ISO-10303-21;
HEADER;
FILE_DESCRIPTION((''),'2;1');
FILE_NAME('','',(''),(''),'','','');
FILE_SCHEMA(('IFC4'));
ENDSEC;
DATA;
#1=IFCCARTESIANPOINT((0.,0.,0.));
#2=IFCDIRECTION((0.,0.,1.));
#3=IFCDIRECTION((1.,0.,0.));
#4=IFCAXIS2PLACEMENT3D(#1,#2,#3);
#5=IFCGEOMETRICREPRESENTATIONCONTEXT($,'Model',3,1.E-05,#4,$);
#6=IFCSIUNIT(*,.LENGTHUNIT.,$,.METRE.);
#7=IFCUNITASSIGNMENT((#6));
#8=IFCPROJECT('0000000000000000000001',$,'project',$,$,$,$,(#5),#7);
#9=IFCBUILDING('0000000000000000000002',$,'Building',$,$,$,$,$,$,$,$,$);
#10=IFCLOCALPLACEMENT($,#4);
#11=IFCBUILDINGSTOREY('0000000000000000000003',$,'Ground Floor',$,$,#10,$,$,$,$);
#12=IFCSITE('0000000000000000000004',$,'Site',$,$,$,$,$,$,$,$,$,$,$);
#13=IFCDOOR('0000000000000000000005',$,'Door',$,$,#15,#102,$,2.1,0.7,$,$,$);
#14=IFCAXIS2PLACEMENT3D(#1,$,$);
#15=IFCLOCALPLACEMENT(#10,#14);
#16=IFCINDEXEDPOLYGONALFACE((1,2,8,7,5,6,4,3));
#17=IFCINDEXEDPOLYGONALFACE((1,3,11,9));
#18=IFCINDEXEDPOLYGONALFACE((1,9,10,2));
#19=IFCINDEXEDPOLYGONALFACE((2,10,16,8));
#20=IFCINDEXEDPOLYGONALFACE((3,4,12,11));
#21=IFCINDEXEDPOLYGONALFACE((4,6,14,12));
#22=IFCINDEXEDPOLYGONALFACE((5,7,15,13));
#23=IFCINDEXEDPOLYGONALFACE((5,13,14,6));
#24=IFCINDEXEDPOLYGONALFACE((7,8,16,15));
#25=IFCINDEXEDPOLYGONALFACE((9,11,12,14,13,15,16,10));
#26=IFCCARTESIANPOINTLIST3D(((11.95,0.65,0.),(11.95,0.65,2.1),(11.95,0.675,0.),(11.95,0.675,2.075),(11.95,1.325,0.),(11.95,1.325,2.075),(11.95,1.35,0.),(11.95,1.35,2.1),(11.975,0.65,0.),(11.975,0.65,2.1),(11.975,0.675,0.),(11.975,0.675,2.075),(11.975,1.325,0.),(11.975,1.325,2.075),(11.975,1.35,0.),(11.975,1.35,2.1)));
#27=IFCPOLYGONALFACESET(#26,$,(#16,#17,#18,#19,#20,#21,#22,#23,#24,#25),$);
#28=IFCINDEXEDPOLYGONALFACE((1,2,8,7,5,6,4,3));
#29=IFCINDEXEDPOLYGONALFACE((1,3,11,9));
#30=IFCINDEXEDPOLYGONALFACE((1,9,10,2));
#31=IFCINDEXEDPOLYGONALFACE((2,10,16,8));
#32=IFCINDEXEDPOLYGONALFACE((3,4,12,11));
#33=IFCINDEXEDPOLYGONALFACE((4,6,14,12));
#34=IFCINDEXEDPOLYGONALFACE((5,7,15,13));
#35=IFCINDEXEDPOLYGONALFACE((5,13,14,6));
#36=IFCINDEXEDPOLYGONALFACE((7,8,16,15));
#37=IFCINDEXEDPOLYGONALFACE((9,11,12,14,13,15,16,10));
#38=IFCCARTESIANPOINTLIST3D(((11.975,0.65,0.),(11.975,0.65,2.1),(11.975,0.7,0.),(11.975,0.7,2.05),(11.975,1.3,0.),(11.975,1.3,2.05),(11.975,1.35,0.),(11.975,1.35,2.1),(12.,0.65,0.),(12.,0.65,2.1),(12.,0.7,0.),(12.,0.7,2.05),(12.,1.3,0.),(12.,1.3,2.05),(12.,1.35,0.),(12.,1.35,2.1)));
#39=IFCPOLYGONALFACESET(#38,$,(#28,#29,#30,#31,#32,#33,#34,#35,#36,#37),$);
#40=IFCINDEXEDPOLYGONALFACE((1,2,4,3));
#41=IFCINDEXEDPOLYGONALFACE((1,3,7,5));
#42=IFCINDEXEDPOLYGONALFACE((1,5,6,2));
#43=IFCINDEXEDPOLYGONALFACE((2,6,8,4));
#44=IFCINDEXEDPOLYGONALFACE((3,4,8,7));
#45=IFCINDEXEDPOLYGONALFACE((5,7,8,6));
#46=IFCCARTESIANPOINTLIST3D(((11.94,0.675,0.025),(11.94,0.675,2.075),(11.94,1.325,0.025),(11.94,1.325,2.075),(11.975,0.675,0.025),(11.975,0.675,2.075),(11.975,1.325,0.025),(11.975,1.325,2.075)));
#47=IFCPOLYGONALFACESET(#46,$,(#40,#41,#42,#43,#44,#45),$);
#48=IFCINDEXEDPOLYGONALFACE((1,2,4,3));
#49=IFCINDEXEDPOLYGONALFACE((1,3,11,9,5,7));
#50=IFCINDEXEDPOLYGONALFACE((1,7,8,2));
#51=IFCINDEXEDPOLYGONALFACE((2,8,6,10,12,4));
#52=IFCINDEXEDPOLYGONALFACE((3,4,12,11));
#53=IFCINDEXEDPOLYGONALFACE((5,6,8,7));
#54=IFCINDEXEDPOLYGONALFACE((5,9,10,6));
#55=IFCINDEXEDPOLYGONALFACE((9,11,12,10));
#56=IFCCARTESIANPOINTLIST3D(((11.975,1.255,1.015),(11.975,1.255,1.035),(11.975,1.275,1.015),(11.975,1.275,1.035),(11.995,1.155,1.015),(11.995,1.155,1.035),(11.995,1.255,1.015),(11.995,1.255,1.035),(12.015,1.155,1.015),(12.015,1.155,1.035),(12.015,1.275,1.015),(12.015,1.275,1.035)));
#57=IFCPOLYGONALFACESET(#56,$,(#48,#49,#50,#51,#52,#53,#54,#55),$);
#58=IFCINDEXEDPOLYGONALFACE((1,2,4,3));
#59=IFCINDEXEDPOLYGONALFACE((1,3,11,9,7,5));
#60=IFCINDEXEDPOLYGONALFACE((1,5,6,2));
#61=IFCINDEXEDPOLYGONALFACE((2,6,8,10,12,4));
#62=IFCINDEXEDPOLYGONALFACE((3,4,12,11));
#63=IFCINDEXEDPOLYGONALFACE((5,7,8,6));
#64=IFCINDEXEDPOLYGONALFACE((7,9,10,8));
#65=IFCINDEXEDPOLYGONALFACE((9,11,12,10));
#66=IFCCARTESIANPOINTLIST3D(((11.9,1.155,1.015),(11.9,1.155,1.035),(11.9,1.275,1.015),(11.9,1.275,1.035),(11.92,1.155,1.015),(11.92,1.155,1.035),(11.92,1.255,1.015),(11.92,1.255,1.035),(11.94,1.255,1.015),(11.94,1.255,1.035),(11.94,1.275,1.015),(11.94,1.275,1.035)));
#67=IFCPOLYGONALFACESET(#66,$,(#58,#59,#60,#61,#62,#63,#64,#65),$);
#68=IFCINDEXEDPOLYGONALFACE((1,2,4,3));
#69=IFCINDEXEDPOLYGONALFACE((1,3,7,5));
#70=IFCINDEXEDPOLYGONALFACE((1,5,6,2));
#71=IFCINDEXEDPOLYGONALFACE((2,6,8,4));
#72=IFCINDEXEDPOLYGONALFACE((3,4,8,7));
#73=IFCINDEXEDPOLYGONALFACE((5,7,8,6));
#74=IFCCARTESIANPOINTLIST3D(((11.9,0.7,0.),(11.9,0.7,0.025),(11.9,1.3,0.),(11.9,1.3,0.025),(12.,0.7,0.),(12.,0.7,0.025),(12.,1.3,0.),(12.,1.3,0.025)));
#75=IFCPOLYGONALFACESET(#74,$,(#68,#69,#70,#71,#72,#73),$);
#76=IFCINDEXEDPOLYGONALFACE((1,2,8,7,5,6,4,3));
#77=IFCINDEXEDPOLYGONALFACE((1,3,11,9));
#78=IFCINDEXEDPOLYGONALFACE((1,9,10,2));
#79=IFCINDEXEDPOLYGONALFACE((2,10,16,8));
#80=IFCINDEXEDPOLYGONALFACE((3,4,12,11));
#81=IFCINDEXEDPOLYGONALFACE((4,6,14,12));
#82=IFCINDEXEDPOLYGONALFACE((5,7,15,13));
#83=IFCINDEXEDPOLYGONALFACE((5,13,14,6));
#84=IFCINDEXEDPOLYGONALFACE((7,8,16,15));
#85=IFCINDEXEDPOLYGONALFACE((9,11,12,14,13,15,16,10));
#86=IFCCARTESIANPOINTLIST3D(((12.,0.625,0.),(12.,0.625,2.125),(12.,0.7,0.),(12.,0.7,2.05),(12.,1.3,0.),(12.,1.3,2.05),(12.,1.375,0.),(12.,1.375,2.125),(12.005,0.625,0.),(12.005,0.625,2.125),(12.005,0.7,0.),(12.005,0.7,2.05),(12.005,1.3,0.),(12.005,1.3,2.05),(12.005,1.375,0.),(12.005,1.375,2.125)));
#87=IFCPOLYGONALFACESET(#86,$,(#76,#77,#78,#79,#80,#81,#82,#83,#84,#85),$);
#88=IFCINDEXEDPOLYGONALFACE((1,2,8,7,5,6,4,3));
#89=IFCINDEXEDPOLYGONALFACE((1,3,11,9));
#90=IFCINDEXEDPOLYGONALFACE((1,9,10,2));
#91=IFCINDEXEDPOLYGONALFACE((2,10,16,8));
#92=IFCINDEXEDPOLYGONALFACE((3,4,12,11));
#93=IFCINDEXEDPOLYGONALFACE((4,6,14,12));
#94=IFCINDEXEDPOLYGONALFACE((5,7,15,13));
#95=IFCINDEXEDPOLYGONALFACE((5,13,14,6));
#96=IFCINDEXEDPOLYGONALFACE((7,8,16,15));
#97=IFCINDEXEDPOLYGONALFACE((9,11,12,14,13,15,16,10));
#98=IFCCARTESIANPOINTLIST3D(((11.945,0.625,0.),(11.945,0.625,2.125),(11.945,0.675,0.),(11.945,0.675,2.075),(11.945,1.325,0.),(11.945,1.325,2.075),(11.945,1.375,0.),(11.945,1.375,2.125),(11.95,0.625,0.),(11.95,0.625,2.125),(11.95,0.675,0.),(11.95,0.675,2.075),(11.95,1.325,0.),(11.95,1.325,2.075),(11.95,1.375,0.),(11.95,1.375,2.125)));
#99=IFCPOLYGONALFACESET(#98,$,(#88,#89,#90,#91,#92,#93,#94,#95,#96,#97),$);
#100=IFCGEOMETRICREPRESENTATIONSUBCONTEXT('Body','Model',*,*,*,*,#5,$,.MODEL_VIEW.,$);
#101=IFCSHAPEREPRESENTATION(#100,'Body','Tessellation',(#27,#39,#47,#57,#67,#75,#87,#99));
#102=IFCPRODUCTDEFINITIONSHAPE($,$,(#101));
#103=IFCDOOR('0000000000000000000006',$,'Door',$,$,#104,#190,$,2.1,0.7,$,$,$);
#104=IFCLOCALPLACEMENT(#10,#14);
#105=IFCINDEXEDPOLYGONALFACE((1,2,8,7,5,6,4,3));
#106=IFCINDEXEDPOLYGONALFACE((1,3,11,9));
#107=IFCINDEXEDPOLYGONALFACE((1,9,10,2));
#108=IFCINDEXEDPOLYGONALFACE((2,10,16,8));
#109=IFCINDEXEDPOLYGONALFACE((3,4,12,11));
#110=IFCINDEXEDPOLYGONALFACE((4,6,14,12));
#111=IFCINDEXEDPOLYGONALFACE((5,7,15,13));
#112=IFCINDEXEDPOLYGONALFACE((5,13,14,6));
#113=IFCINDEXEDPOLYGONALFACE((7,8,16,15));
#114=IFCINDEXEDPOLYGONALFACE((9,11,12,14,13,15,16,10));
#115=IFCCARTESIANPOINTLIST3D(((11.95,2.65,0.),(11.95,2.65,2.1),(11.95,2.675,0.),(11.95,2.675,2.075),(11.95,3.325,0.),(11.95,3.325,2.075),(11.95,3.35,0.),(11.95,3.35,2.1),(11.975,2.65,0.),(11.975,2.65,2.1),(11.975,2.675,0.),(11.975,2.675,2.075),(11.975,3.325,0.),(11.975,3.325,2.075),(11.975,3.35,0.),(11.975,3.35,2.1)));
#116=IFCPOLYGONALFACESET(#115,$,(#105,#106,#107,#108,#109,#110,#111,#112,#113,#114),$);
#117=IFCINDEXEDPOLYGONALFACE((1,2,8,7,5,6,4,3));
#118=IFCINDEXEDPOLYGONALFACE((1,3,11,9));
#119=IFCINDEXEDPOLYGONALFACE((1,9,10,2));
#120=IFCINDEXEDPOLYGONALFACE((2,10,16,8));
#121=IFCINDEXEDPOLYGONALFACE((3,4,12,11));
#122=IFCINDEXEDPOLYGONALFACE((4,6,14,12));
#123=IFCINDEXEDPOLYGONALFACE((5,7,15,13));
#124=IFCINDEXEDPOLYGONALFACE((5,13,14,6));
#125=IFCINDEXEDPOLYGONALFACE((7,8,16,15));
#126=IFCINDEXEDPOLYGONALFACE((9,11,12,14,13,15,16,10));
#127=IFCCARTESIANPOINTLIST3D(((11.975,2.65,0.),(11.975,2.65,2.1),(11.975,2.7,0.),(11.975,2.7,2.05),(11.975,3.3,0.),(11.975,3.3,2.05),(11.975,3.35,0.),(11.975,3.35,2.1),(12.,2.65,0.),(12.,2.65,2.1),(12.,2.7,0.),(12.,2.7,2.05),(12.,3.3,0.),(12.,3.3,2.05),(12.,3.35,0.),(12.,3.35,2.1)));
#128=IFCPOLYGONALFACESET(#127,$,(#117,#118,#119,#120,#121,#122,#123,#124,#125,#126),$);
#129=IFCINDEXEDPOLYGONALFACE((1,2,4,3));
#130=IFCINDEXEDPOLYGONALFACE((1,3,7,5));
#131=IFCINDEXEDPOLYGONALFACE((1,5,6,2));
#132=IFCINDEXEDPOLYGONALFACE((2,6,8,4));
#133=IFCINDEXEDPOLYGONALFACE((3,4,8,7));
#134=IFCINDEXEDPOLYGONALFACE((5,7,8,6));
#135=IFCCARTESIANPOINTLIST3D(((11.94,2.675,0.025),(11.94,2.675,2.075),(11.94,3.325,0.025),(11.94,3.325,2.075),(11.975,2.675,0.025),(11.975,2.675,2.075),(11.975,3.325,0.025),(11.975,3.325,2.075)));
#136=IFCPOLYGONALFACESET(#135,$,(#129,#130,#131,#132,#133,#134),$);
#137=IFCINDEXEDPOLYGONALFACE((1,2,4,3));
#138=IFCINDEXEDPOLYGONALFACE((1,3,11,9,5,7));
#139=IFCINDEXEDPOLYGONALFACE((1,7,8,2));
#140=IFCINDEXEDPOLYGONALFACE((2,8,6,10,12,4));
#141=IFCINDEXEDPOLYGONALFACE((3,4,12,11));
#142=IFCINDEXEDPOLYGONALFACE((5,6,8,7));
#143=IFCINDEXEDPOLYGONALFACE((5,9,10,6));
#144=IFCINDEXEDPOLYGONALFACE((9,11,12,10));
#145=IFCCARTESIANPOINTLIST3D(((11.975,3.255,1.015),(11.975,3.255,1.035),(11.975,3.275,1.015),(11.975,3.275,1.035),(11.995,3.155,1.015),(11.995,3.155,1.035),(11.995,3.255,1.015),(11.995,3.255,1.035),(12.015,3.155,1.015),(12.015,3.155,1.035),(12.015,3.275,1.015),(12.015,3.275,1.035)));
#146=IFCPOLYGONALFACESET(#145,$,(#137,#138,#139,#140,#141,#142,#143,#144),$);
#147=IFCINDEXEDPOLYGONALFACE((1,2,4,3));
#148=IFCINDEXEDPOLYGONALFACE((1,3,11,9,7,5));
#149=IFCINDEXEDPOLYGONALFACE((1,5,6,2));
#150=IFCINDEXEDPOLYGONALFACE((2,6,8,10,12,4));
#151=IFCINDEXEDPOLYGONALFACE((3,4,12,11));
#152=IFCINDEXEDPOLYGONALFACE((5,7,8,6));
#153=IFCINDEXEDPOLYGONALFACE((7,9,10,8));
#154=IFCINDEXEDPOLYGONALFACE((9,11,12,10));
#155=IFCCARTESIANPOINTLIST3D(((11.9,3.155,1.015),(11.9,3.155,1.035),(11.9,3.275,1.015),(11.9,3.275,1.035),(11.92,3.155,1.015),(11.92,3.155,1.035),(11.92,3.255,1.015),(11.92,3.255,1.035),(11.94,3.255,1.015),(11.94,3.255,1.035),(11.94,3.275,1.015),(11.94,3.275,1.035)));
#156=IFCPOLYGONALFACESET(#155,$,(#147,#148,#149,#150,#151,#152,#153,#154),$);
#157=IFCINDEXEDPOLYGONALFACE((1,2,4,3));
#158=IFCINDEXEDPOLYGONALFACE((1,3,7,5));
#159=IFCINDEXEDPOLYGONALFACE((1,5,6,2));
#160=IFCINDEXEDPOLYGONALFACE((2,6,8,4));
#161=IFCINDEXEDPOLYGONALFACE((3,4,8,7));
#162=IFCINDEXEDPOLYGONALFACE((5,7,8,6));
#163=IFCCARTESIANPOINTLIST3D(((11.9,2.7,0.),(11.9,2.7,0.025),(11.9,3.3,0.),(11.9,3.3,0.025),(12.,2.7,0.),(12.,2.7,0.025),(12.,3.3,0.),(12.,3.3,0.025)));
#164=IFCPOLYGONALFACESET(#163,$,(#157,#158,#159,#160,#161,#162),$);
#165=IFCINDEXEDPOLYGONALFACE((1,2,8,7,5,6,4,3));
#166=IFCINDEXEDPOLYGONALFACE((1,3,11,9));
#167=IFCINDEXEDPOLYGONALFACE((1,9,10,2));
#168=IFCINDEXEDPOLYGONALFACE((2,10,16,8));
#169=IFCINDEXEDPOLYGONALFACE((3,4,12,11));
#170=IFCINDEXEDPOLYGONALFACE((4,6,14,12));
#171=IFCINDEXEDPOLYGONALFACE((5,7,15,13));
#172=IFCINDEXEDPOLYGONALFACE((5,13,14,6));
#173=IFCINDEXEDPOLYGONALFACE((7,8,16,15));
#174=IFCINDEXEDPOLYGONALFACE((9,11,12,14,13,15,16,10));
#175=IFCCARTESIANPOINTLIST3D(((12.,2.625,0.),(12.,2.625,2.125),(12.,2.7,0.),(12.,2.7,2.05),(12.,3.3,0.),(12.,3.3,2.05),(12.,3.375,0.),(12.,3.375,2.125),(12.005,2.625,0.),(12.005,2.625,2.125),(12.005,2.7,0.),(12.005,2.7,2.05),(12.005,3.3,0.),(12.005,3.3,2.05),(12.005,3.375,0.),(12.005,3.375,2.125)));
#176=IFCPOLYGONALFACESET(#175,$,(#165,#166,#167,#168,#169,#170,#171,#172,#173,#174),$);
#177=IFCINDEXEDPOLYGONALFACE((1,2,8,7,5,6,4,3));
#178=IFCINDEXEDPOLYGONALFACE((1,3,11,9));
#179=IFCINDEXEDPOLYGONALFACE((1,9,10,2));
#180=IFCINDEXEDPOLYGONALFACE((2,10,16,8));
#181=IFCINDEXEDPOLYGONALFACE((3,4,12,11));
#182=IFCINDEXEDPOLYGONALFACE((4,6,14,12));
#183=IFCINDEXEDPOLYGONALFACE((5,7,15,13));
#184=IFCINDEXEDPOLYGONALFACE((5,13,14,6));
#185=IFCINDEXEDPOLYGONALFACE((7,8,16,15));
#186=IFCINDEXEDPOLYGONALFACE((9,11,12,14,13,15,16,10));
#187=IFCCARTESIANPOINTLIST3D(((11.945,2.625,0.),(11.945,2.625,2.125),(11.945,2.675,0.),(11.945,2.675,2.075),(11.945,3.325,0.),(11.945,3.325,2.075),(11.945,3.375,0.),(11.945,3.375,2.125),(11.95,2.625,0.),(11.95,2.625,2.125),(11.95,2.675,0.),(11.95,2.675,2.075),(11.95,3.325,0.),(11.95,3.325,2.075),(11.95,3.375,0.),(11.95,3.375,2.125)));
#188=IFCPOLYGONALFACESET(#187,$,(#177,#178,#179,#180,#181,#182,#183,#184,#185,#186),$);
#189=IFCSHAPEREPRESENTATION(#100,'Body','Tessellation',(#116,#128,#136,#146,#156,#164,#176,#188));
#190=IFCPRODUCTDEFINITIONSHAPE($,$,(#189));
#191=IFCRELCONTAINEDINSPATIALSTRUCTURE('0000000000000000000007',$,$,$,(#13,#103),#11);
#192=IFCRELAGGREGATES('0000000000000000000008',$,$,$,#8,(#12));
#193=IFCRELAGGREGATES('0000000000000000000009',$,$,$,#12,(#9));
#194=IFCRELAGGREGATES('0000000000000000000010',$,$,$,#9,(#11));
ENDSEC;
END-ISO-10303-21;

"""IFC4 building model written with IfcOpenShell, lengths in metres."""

from ifc_helpers import new_model, si_unit, frame, origin_with_axes, place, context, subcontext, project, spatial, line, indexed_curve, outline, extrude, element, save


model = new_model("IFC4")

# Units and contexts
model_context = context("Model", 3, precision=1e-05, world=origin_with_axes())
body_context = subcontext(model_context, "Body", "Model", "MODEL_VIEW")
ifc_project = project(units=[si_unit("LENGTHUNIT", "METRE")], contexts=[model_context])

# Site, building, storey
site = spatial("IfcSite", under=ifc_project, Name="Site")
building = spatial("IfcBuilding", under=site, Name="Building")
storey_placement = place(None, origin_with_axes())
storey = spatial("IfcBuildingStorey", under=building, at=storey_placement, Name="Ground Floor")

# Doors
door_1_placement = place(storey_placement, frame((12.0, 0.65, 0.0), z_axis=(0.0, 0.0, 1.0), x_axis=(0.0, 1.0, 0.0)))
element("IfcDoor", 1, at=door_1_placement, inside=storey, Name="Door", OverallHeight=2.1, OverallWidth=0.7, context=body_context, shape_type="SweptSolid", body=[
    extrude(outline(indexed_curve([(0.0, 0.0), (0.0, 2.1), (0.7, 2.1), (0.7, 0.0), (0.675, 0.0), (0.675, 2.075), (0.025, 2.075), (0.025, 0.0)], segments=[line(1, 2, 3, 4, 5, 6, 7, 8, 1)])), frame((0.0, 0.025, 0.0), z_axis=(0.0, -1.0, 0.0), x_axis=(1.0, 0.0, 0.0)), (0.0, 0.0, -1.0), 0.025),
    extrude(outline(indexed_curve([(0.0, 0.0), (0.0, 2.1), (0.7, 2.1), (0.7, 0.0), (0.65, 0.0), (0.65, 2.05), (0.05, 2.05), (0.05, 0.0)], segments=[line(1, 2, 3, 4, 5, 6, 7, 8, 1)])), frame((0.0, 0.0, 0.0), z_axis=(0.0, -1.0, 0.0), x_axis=(1.0, 0.0, 0.0)), (0.0, 0.0, -1.0), 0.025),
    extrude(outline(indexed_curve([(0.0, 0.0), (0.65, 0.0), (0.65, 0.035), (0.0, 0.035)], segments=[line(1, 2, 3, 4, 1)])), frame((0.025, 0.025, 0.025), z_axis=(0.0, 0.0, 1.0), x_axis=(1.0, 0.0, 0.0)), (0.0, 0.0, 1.0), 2.05),
    extrude(outline(indexed_curve([(0.0, 0.0), (0.0, -0.04), (-0.12, -0.04), (-0.12, -0.02), (-0.02, -0.02), (-0.02, 0.0)], segments=[line(1, 2, 3, 4, 5, 6, 1)])), frame((0.625, 0.025, 1.015), z_axis=(0.0, 0.0, 1.0), x_axis=(1.0, 0.0, 0.0)), (0.0, 0.0, 1.0), 0.02),
    extrude(outline(indexed_curve([(0.0, 0.0), (0.0, 0.04), (-0.12, 0.04), (-0.12, 0.02), (-0.02, 0.02), (-0.02, 0.0)], segments=[line(1, 2, 3, 4, 5, 6, 1)])), frame((0.625, 0.06, 1.015), z_axis=(0.0, 0.0, 1.0), x_axis=(1.0, 0.0, 0.0)), (0.0, 0.0, 1.0), 0.02),
    extrude(outline(indexed_curve([(0.0, 0.0), (0.6, 0.0), (0.6, 0.1), (0.0, 0.1)], segments=[line(1, 2, 3, 4, 1)])), frame((0.05, 0.0, 0.0), z_axis=(0.0, 0.0, 1.0), x_axis=(1.0, 0.0, 0.0)), (0.0, 0.0, 1.0), 0.025),
    extrude(outline(indexed_curve([(0.0, 0.0), (0.0, 2.125), (0.75, 2.125), (0.75, 0.0), (0.675, 0.0), (0.675, 2.05), (0.075, 2.05), (0.075, 0.0)], segments=[line(1, 2, 3, 4, 5, 6, 7, 8, 1)])), frame((-0.025, -0.005, 0.0), z_axis=(0.0, -1.0, 0.0), x_axis=(1.0, 0.0, 0.0)), (0.0, 0.0, -1.0), 0.005),
    extrude(outline(indexed_curve([(0.0, 0.0), (0.0, 2.125), (0.75, 2.125), (0.75, 0.0), (0.7, 0.0), (0.7, 2.075), (0.05, 2.075), (0.05, 0.0)], segments=[line(1, 2, 3, 4, 5, 6, 7, 8, 1)])), frame((-0.025, 0.05, 0.0), z_axis=(0.0, -1.0, 0.0), x_axis=(1.0, 0.0, 0.0)), (0.0, 0.0, -1.0), 0.005),
])
door_2_placement = place(storey_placement, frame((12.0, 2.65, 0.0), z_axis=(0.0, 0.0, 1.0), x_axis=(0.0, 1.0, 0.0)))
element("IfcDoor", 2, at=door_2_placement, inside=storey, Name="Door", OverallHeight=2.1, OverallWidth=0.7, context=body_context, shape_type="SweptSolid", body=[
    extrude(outline(indexed_curve([(0.0, 0.0), (0.0, 2.1), (0.7, 2.1), (0.7, 0.0), (0.675, 0.0), (0.675, 2.075), (0.025, 2.075), (0.025, 0.0)], segments=[line(1, 2, 3, 4, 5, 6, 7, 8, 1)])), frame((0.0, 0.025, 0.0), z_axis=(0.0, -1.0, 0.0), x_axis=(1.0, 0.0, 0.0)), (0.0, 0.0, -1.0), 0.025),
    extrude(outline(indexed_curve([(0.0, 0.0), (0.0, 2.1), (0.7, 2.1), (0.7, 0.0), (0.65, 0.0), (0.65, 2.05), (0.05, 2.05), (0.05, 0.0)], segments=[line(1, 2, 3, 4, 5, 6, 7, 8, 1)])), frame((0.0, 0.0, 0.0), z_axis=(0.0, -1.0, 0.0), x_axis=(1.0, 0.0, 0.0)), (0.0, 0.0, -1.0), 0.025),
    extrude(outline(indexed_curve([(0.0, 0.0), (0.65, 0.0), (0.65, 0.035), (0.0, 0.035)], segments=[line(1, 2, 3, 4, 1)])), frame((0.025, 0.025, 0.025), z_axis=(0.0, 0.0, 1.0), x_axis=(1.0, 0.0, 0.0)), (0.0, 0.0, 1.0), 2.05),
    extrude(outline(indexed_curve([(0.0, 0.0), (0.0, -0.04), (-0.12, -0.04), (-0.12, -0.02), (-0.02, -0.02), (-0.02, 0.0)], segments=[line(1, 2, 3, 4, 5, 6, 1)])), frame((0.625, 0.025, 1.015), z_axis=(0.0, 0.0, 1.0), x_axis=(1.0, 0.0, 0.0)), (0.0, 0.0, 1.0), 0.02),
    extrude(outline(indexed_curve([(0.0, 0.0), (0.0, 0.04), (-0.12, 0.04), (-0.12, 0.02), (-0.02, 0.02), (-0.02, 0.0)], segments=[line(1, 2, 3, 4, 5, 6, 1)])), frame((0.625, 0.06, 1.015), z_axis=(0.0, 0.0, 1.0), x_axis=(1.0, 0.0, 0.0)), (0.0, 0.0, 1.0), 0.02),
    extrude(outline(indexed_curve([(0.0, 0.0), (0.6, 0.0), (0.6, 0.1), (0.0, 0.1)], segments=[line(1, 2, 3, 4, 1)])), frame((0.05, 0.0, 0.0), z_axis=(0.0, 0.0, 1.0), x_axis=(1.0, 0.0, 0.0)), (0.0, 0.0, 1.0), 0.025),
    extrude(outline(indexed_curve([(0.0, 0.0), (0.0, 2.125), (0.75, 2.125), (0.75, 0.0), (0.675, 0.0), (0.675, 2.05), (0.075, 2.05), (0.075, 0.0)], segments=[line(1, 2, 3, 4, 5, 6, 7, 8, 1)])), frame((-0.025, -0.005, 0.0), z_axis=(0.0, -1.0, 0.0), x_axis=(1.0, 0.0, 0.0)), (0.0, 0.0, -1.0), 0.005),
    extrude(outline(indexed_curve([(0.0, 0.0), (0.0, 2.125), (0.75, 2.125), (0.75, 0.0), (0.7, 0.0), (0.7, 2.075), (0.05, 2.075), (0.05, 0.0)], segments=[line(1, 2, 3, 4, 5, 6, 7, 8, 1)])), frame((-0.025, 0.05, 0.0), z_axis=(0.0, -1.0, 0.0), x_axis=(1.0, 0.0, 0.0)), (0.0, 0.0, -1.0), 0.005),
])

save(model, "model.ifc")
